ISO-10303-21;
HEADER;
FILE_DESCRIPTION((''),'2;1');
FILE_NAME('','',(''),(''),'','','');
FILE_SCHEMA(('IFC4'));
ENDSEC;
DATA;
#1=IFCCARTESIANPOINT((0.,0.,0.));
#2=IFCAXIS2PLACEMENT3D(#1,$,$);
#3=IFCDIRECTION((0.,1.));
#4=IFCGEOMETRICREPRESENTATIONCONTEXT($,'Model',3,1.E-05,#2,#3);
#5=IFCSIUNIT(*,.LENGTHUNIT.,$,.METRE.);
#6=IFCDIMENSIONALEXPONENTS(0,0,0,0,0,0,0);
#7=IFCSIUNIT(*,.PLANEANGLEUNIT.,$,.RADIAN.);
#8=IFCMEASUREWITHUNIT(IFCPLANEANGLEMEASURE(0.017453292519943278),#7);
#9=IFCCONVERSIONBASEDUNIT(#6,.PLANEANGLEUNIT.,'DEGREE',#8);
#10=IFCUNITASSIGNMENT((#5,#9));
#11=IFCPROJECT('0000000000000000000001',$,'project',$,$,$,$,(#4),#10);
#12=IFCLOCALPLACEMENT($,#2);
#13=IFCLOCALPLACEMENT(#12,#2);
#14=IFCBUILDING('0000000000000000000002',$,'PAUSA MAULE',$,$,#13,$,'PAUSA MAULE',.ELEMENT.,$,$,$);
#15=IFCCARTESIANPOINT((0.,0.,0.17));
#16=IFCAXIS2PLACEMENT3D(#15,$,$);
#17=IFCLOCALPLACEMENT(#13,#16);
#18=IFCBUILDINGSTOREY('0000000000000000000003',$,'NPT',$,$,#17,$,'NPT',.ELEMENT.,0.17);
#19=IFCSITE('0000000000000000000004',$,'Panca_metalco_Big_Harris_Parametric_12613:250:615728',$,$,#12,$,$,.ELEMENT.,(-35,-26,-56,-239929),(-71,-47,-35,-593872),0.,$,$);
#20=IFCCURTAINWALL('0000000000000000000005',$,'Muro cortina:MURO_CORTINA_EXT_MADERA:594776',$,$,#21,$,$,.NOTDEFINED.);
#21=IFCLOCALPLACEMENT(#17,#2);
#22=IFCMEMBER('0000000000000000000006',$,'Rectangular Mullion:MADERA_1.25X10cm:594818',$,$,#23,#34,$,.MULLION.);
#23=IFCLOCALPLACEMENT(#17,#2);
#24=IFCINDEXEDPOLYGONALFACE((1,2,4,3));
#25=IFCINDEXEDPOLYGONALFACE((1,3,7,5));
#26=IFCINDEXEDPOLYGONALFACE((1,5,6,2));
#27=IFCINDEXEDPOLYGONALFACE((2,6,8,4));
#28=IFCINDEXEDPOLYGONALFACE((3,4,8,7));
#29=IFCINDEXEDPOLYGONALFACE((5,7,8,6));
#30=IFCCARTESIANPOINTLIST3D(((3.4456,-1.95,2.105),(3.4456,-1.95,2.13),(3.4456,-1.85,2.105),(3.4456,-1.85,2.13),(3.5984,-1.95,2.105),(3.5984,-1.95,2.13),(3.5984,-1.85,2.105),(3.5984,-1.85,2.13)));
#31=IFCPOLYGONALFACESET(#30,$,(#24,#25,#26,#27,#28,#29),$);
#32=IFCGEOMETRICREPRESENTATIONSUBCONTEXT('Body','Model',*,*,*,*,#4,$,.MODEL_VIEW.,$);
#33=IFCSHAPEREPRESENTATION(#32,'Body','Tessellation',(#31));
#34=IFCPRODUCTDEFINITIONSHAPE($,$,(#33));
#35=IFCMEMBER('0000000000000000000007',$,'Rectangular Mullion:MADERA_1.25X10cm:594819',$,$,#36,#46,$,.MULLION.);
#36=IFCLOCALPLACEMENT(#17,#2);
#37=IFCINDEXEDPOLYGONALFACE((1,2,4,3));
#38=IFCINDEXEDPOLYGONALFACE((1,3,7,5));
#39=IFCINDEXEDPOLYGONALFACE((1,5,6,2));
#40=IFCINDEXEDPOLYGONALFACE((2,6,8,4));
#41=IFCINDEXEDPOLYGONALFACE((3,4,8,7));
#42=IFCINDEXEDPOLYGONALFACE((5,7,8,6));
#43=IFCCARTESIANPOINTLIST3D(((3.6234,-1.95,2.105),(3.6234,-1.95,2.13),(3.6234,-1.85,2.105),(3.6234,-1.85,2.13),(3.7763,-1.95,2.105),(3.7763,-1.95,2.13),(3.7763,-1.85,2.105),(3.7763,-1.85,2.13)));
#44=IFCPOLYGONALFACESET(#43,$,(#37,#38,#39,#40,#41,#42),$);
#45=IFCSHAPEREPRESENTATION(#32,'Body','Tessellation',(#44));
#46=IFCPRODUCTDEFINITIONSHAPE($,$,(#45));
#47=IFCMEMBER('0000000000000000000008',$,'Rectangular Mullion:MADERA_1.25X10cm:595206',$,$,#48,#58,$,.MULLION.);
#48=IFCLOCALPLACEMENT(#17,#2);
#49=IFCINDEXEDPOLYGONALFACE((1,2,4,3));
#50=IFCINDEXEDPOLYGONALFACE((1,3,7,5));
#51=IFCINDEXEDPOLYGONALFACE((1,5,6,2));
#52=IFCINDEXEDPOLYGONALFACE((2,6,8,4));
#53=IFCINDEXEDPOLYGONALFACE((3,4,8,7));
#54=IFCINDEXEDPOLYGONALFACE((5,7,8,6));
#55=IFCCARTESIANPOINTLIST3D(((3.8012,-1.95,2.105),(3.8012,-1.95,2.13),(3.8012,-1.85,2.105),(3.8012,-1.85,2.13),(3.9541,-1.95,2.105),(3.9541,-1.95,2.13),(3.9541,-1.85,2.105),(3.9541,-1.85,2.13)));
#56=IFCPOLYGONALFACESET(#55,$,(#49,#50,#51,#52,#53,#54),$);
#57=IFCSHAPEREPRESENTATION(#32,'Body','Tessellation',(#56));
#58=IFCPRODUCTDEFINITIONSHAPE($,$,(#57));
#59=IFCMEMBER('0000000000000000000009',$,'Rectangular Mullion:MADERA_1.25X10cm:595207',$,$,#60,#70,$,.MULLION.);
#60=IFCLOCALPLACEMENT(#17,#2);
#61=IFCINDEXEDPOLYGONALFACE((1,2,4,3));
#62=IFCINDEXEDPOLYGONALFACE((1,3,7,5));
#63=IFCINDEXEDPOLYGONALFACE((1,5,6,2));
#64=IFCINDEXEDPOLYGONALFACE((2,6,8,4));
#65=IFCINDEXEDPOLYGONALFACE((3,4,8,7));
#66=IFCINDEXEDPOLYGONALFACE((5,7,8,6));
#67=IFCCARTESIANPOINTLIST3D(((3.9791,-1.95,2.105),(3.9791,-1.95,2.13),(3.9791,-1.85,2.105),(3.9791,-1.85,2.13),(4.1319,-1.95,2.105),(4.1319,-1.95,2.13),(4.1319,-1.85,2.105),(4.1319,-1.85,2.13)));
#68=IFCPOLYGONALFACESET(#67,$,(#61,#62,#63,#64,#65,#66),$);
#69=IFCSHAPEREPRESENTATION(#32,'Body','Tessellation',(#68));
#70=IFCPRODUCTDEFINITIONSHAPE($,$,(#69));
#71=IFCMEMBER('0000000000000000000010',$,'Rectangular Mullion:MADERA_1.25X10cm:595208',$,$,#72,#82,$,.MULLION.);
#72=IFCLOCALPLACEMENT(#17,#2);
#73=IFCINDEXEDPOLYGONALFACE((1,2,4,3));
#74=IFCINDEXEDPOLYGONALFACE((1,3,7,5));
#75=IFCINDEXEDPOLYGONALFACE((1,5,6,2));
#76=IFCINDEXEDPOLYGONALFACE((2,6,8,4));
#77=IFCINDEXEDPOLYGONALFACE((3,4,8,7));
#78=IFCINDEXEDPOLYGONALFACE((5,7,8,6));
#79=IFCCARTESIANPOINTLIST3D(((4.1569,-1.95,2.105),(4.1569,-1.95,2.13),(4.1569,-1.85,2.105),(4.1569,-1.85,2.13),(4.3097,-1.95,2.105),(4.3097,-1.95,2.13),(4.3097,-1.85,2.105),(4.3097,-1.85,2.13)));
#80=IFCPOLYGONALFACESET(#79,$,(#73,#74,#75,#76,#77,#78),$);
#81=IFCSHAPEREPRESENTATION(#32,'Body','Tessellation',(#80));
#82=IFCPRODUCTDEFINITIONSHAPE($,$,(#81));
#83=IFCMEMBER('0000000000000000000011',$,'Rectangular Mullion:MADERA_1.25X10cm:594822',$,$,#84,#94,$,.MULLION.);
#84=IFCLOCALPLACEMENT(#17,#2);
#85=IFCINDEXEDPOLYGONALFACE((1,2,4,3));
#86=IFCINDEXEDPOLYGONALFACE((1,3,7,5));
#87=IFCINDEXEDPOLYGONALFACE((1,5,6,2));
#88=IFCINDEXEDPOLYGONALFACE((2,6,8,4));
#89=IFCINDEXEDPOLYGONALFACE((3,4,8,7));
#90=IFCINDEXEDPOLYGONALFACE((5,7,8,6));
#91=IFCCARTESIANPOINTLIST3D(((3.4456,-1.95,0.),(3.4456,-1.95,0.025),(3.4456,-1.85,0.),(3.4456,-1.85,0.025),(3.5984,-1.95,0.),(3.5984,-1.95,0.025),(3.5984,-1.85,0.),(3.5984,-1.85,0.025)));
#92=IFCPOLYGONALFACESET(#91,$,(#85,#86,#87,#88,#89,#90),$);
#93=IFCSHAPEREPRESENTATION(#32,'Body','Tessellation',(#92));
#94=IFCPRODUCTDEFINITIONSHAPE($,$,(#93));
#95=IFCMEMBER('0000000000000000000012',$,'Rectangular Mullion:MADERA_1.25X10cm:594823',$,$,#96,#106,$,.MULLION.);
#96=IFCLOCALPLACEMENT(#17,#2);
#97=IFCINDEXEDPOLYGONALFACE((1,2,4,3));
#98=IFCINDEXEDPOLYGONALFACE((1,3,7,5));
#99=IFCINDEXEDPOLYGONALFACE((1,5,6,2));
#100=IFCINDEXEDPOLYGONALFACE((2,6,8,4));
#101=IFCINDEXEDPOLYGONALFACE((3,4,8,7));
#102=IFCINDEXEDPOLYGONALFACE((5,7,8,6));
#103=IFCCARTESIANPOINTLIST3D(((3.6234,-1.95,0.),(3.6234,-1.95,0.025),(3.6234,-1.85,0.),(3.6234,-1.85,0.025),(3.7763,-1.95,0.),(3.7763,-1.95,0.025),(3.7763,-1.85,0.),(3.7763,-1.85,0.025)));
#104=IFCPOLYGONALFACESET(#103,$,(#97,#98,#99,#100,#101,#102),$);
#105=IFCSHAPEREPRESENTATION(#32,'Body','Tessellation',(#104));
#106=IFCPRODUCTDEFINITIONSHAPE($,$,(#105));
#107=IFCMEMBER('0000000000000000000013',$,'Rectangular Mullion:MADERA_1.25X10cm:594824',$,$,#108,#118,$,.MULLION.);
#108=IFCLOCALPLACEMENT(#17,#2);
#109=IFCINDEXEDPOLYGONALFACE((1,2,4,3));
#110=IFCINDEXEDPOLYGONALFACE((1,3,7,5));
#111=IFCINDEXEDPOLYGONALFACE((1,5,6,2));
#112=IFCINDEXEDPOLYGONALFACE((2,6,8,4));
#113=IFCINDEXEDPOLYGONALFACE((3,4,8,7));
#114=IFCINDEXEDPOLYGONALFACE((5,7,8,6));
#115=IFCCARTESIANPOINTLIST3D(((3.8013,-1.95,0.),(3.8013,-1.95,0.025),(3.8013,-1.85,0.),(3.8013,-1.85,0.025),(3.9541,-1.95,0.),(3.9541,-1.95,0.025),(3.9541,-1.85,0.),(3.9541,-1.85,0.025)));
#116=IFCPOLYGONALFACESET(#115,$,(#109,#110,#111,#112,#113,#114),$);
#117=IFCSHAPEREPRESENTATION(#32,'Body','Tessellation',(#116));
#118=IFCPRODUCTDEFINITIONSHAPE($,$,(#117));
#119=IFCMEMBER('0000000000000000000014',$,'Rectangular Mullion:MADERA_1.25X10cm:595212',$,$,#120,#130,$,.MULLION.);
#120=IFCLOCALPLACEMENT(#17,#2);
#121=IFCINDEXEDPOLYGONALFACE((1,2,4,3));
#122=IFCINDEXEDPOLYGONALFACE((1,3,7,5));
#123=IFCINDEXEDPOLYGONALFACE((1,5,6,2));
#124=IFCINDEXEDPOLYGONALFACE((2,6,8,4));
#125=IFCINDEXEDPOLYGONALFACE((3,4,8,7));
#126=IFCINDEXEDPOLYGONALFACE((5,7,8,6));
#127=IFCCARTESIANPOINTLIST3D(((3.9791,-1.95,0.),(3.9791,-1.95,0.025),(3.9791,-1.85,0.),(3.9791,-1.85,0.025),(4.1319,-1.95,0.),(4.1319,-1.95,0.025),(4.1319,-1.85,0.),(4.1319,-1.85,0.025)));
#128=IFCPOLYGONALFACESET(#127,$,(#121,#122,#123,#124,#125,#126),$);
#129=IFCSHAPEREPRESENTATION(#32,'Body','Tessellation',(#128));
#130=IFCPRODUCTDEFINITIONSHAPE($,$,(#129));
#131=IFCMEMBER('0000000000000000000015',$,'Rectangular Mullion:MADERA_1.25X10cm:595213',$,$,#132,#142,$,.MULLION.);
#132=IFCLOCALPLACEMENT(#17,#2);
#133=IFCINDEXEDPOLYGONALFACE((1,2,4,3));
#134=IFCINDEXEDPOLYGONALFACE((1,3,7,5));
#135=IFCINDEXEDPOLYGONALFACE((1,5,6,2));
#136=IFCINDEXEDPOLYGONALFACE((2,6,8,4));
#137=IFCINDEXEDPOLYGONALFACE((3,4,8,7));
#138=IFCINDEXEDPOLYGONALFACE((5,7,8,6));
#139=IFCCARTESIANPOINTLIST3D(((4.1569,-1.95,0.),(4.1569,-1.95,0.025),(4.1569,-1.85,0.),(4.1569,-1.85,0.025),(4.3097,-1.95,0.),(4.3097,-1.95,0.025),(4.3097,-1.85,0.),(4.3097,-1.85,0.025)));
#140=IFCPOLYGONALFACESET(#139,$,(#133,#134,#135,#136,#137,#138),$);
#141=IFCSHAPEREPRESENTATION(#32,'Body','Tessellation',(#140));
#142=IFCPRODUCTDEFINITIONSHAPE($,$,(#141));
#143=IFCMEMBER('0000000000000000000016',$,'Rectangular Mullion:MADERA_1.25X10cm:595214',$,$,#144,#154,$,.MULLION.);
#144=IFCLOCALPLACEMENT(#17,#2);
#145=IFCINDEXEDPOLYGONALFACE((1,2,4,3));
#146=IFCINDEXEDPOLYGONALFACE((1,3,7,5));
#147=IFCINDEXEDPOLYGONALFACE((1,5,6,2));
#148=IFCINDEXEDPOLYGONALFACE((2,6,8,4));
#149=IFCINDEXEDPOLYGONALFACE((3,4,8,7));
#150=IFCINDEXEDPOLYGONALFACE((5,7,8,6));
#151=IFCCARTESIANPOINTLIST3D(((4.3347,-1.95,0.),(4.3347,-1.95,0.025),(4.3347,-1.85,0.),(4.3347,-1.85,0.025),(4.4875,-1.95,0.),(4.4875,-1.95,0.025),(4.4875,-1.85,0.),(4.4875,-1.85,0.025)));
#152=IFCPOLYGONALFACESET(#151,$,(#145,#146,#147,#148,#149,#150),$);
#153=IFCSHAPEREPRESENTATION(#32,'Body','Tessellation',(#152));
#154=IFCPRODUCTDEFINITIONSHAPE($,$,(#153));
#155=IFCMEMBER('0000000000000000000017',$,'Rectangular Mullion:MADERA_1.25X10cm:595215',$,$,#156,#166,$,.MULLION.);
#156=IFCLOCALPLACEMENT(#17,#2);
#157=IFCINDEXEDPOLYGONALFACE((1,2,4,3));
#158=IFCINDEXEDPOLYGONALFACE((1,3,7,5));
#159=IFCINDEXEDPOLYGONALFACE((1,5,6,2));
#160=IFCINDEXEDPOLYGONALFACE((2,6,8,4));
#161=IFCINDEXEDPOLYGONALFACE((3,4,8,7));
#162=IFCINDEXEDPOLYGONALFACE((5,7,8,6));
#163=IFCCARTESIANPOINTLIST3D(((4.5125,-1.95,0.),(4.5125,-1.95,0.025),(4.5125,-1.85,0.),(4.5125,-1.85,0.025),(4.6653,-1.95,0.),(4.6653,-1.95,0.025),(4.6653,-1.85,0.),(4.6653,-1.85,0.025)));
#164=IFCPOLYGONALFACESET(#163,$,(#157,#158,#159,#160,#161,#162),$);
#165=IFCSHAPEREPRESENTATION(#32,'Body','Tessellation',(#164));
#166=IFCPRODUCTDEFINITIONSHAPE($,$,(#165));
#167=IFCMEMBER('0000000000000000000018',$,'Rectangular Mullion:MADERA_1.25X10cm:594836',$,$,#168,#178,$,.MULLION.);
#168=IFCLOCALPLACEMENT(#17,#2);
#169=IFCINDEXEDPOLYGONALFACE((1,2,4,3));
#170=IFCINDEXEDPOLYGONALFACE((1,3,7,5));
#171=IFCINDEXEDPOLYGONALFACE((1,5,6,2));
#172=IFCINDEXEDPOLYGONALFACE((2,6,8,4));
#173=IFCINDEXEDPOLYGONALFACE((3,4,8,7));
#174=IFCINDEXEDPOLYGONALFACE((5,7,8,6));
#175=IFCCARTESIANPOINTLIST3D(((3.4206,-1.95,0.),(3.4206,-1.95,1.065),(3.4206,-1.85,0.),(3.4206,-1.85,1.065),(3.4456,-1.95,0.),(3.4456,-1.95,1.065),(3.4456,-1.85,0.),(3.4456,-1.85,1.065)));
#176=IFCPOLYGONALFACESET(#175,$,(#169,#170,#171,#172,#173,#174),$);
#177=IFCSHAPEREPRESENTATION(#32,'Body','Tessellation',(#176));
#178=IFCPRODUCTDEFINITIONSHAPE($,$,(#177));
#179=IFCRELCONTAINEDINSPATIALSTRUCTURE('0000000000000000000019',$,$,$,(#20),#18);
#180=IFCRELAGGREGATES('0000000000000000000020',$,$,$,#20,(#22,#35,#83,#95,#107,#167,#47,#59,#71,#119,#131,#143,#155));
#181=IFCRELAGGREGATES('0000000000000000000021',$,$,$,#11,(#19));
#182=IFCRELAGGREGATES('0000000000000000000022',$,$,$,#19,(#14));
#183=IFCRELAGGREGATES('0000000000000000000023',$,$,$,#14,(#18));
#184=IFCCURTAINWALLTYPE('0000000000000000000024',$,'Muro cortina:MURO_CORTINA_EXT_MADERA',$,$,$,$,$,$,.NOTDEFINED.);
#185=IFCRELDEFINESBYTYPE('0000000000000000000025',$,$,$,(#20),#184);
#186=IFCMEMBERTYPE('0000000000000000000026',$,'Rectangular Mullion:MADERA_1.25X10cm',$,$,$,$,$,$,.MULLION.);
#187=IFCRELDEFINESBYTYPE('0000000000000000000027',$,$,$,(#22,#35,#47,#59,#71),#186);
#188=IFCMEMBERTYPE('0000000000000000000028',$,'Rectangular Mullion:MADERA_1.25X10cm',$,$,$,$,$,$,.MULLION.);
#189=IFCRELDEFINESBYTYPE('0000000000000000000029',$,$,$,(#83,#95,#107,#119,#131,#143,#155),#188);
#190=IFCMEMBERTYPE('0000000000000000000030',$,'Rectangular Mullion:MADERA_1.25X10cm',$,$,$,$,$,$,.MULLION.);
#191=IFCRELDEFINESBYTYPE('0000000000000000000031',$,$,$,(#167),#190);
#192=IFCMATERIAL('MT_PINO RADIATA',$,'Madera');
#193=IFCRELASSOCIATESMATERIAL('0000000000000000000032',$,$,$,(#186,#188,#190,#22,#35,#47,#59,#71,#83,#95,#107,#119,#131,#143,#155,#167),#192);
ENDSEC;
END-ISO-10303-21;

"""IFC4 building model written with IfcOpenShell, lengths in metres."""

from ifc_helpers import new_model, entity, si_unit, converted_unit, direction, frame, frame_2d, origin, place, context, subcontext, project, spatial, rectangle, extrude, source, transform, mapped, material, material_profile, profile_set, profile_usage, type_object, type_shapes, element, aggregate, save


model = new_model("IFC4")

# Units and contexts
model_context = context("Model", 3, precision=1e-05, world=origin(), true_north=direction((0.0, 1.0)))
body_context = subcontext(model_context, "Body", "Model", "MODEL_VIEW")
ifc_project = project(units=[si_unit("LENGTHUNIT", "METRE"), converted_unit("PLANEANGLEUNIT", "DEGREE", entity("IfcPlaneAngleMeasure", 0.017453292519943278), si_unit("PLANEANGLEUNIT", "RADIAN"), dimensions=[0, 0, 0, 0, 0, 0, 0])], contexts=[model_context])

# Site, building, storey
site_placement = place(None, origin())
site = spatial("IfcSite", under=ifc_project, at=site_placement, Name="Panca_metalco_Big_Harris_Parametric_12613:250:615728", CompositionType="ELEMENT", RefLatitude=(-35, -26, -56, -239929), RefLongitude=(-71, -47, -35, -593872), RefElevation=0.0)
building_placement = place(site_placement, origin())
building = spatial("IfcBuilding", under=site, at=building_placement, Name="PAUSA MAULE", LongName="PAUSA MAULE", CompositionType="ELEMENT")
storey_placement = place(building_placement, frame((0.0, 0.0, 0.17)))
storey = spatial("IfcBuildingStorey", under=building, at=storey_placement, Name="NPT", LongName="NPT", CompositionType="ELEMENT", Elevation=0.17)

# Curtain wall, members
curtain_wall_type = type_object("IfcCurtainWallType", Name="Muro cortina:MURO_CORTINA_EXT_MADERA", PredefinedType="NOTDEFINED")
curtain_wall_placement = place(storey_placement, frame((0.0, 0.0, -0.17)))
curtain_wall = element("IfcCurtainWall", 1, at=curtain_wall_placement, inside=storey, type_object=curtain_wall_type, Name="Muro cortina:MURO_CORTINA_EXT_MADERA:594776", PredefinedType="NOTDEFINED")
ifc_material = material(Name="MT_PINO RADIATA", Category="Madera")
ifc_material_profile = material_profile(ifc_material, rectangle(XDim=0.025, YDim=0.1, at=frame_2d((0.0, 0.0), x_axis=(1.0, 0.0))), Name="MADERA_1.25X10cm")
ifc_profile_set = profile_set([ifc_material_profile], Name="MADERA_1.25X10cm")
ifc_profile_usage = profile_usage(ifc_profile_set)
member_type_1 = type_object("IfcMemberType", Name="Rectangular Mullion:MADERA_1.25X10cm", PredefinedType="MULLION", material=ifc_profile_set)
shared_shape_1 = source(origin(), body_context, "Body", "SweptSolid", [
    extrude(rectangle(XDim=0.025, YDim=0.1, at=frame_2d((0.0, 0.0), x_axis=(1.0, 0.0))), frame((-0.0125, 0.0, -0.1528), z_axis=(0.0, 0.0, 1.0), x_axis=(-1.0, 0.0, 0.0)), (0.0, 0.0, 1.0), 0.1528),
])
type_shapes(member_type_1, [shared_shape_1])
member_1_placement = place(curtain_wall_placement, frame((3.5984, -1.9, 2.3), z_axis=(1.0, 0.0, 0.0), x_axis=(0.0, 0.0, 1.0)))
member_1 = element("IfcMember", 2, at=member_1_placement, type_object=member_type_1, material=ifc_profile_usage, Name="Rectangular Mullion:MADERA_1.25X10cm:594818", PredefinedType="MULLION", context=body_context, shape_type="MappedRepresentation", body=[
    mapped(shared_shape_1, transform((0.0, 0.0, 0.0), scale=1.0)),
])
member_2_placement = place(curtain_wall_placement, frame((3.7763, -1.9, 2.3), z_axis=(1.0, 0.0, 0.0), x_axis=(0.0, 0.0, 1.0)))
member_2 = element("IfcMember", 3, at=member_2_placement, type_object=member_type_1, material=ifc_profile_usage, Name="Rectangular Mullion:MADERA_1.25X10cm:594819", PredefinedType="MULLION", context=body_context, shape_type="MappedRepresentation", body=[
    mapped(shared_shape_1, transform((0.0, 0.0, 0.0), scale=1.0)),
])
member_3_placement = place(curtain_wall_placement, frame((3.9541, -1.9, 2.3), z_axis=(1.0, 0.0, 0.0), x_axis=(0.0, 0.0, 1.0)))
member_3 = element("IfcMember", 4, at=member_3_placement, type_object=member_type_1, material=ifc_profile_usage, Name="Rectangular Mullion:MADERA_1.25X10cm:595206", PredefinedType="MULLION", context=body_context, shape_type="MappedRepresentation", body=[
    mapped(shared_shape_1, transform((0.0, 0.0, 0.0), scale=1.0)),
])
member_4_placement = place(curtain_wall_placement, frame((4.1319, -1.9, 2.3), z_axis=(1.0, 0.0, 0.0), x_axis=(0.0, 0.0, 1.0)))
member_4 = element("IfcMember", 5, at=member_4_placement, type_object=member_type_1, material=ifc_profile_usage, Name="Rectangular Mullion:MADERA_1.25X10cm:595207", PredefinedType="MULLION", context=body_context, shape_type="MappedRepresentation", body=[
    mapped(shared_shape_1, transform((0.0, 0.0, 0.0), scale=1.0)),
])
member_5_placement = place(curtain_wall_placement, frame((4.3097, -1.9, 2.3), z_axis=(1.0, 0.0, 0.0), x_axis=(0.0, 0.0, 1.0)))
member_5 = element("IfcMember", 6, at=member_5_placement, type_object=member_type_1, material=ifc_profile_usage, Name="Rectangular Mullion:MADERA_1.25X10cm:595208", PredefinedType="MULLION", context=body_context, shape_type="MappedRepresentation", body=[
    mapped(shared_shape_1, transform((0.0, 0.0, 0.0), scale=1.0)),
])
member_type_2 = type_object("IfcMemberType", Name="Rectangular Mullion:MADERA_1.25X10cm", PredefinedType="MULLION", material=ifc_profile_set)
shared_shape_2 = source(origin(), body_context, "Body", "SweptSolid", [
    extrude(rectangle(XDim=0.025, YDim=0.1, at=frame_2d((0.0, 0.0), x_axis=(1.0, 0.0))), frame((-0.0125, 0.0, -0.1528), z_axis=(0.0, 0.0, 1.0), x_axis=(-1.0, 0.0, 0.0)), (0.0, 0.0, 1.0), 0.1528),
])
type_shapes(member_type_2, [shared_shape_2])
member_6_placement = place(curtain_wall_placement, frame((3.4456, -1.9, 0.17), z_axis=(-1.0, 0.0, 0.0), x_axis=(0.0, 0.0, -1.0)))
member_6 = element("IfcMember", 7, at=member_6_placement, type_object=member_type_2, material=ifc_profile_usage, Name="Rectangular Mullion:MADERA_1.25X10cm:594822", PredefinedType="MULLION", context=body_context, shape_type="MappedRepresentation", body=[
    mapped(shared_shape_2, transform((0.0, 0.0, 0.0), scale=1.0)),
])
member_7_placement = place(curtain_wall_placement, frame((3.6234, -1.9, 0.17), z_axis=(-1.0, 0.0, 0.0), x_axis=(0.0, 0.0, -1.0)))
member_7 = element("IfcMember", 8, at=member_7_placement, type_object=member_type_2, material=ifc_profile_usage, Name="Rectangular Mullion:MADERA_1.25X10cm:594823", PredefinedType="MULLION", context=body_context, shape_type="MappedRepresentation", body=[
    mapped(shared_shape_2, transform((0.0, 0.0, 0.0), scale=1.0)),
])
member_8_placement = place(curtain_wall_placement, frame((3.8013, -1.9, 0.17), z_axis=(-1.0, 0.0, 0.0), x_axis=(0.0, 0.0, -1.0)))
member_8 = element("IfcMember", 9, at=member_8_placement, type_object=member_type_2, material=ifc_profile_usage, Name="Rectangular Mullion:MADERA_1.25X10cm:594824", PredefinedType="MULLION", context=body_context, shape_type="MappedRepresentation", body=[
    mapped(shared_shape_2, transform((0.0, 0.0, 0.0), scale=1.0)),
])
member_9_placement = place(curtain_wall_placement, frame((3.9791, -1.9, 0.17), z_axis=(-1.0, 0.0, 0.0), x_axis=(0.0, 0.0, -1.0)))
member_9 = element("IfcMember", 10, at=member_9_placement, type_object=member_type_2, material=ifc_profile_usage, Name="Rectangular Mullion:MADERA_1.25X10cm:595212", PredefinedType="MULLION", context=body_context, shape_type="MappedRepresentation", body=[
    mapped(shared_shape_2, transform((0.0, 0.0, 0.0), scale=1.0)),
])
member_10_placement = place(curtain_wall_placement, frame((4.1569, -1.9, 0.17), z_axis=(-1.0, 0.0, 0.0), x_axis=(0.0, 0.0, -1.0)))
member_10 = element("IfcMember", 11, at=member_10_placement, type_object=member_type_2, material=ifc_profile_usage, Name="Rectangular Mullion:MADERA_1.25X10cm:595213", PredefinedType="MULLION", context=body_context, shape_type="MappedRepresentation", body=[
    mapped(shared_shape_2, transform((0.0, 0.0, 0.0), scale=1.0)),
])
member_11_placement = place(curtain_wall_placement, frame((4.3347, -1.9, 0.17), z_axis=(-1.0, 0.0, 0.0), x_axis=(0.0, 0.0, -1.0)))
member_11 = element("IfcMember", 12, at=member_11_placement, type_object=member_type_2, material=ifc_profile_usage, Name="Rectangular Mullion:MADERA_1.25X10cm:595214", PredefinedType="MULLION", context=body_context, shape_type="MappedRepresentation", body=[
    mapped(shared_shape_2, transform((0.0, 0.0, 0.0), scale=1.0)),
])
member_12_placement = place(curtain_wall_placement, frame((4.5125, -1.9, 0.17), z_axis=(-1.0, 0.0, 0.0), x_axis=(0.0, 0.0, -1.0)))
member_12 = element("IfcMember", 13, at=member_12_placement, type_object=member_type_2, material=ifc_profile_usage, Name="Rectangular Mullion:MADERA_1.25X10cm:595215", PredefinedType="MULLION", context=body_context, shape_type="MappedRepresentation", body=[
    mapped(shared_shape_2, transform((0.0, 0.0, 0.0), scale=1.0)),
])
member_type_3 = type_object("IfcMemberType", Name="Rectangular Mullion:MADERA_1.25X10cm", PredefinedType="MULLION", material=ifc_profile_set)
shared_shape_3 = source(origin(), body_context, "Body", "SweptSolid", [
    extrude(rectangle(XDim=0.025, YDim=0.1, at=frame_2d((0.0, 0.0), x_axis=(1.0, 0.0))), frame((0.0, 0.0, -1.065), z_axis=(0.0, 0.0, 1.0), x_axis=(-1.0, 0.0, 0.0)), (0.0, 0.0, 1.0), 1.065),
])
type_shapes(member_type_3, [shared_shape_3])
member_13_placement = place(curtain_wall_placement, frame((3.4331, -1.9, 0.17), z_axis=(0.0, 0.0, -1.0), x_axis=(1.0, 0.0, 0.0)))
member_13 = element("IfcMember", 14, at=member_13_placement, type_object=member_type_3, material=ifc_profile_usage, Name="Rectangular Mullion:MADERA_1.25X10cm:594836", PredefinedType="MULLION", context=body_context, shape_type="MappedRepresentation", body=[
    mapped(shared_shape_3, transform((0.0, 0.0, 0.0), scale=1.0)),
])
aggregate(curtain_wall, [member_1, member_2, member_6, member_7, member_8, member_13, member_3, member_4, member_5, member_9, member_10, member_11, member_12])

save(model, "model.ifc")
